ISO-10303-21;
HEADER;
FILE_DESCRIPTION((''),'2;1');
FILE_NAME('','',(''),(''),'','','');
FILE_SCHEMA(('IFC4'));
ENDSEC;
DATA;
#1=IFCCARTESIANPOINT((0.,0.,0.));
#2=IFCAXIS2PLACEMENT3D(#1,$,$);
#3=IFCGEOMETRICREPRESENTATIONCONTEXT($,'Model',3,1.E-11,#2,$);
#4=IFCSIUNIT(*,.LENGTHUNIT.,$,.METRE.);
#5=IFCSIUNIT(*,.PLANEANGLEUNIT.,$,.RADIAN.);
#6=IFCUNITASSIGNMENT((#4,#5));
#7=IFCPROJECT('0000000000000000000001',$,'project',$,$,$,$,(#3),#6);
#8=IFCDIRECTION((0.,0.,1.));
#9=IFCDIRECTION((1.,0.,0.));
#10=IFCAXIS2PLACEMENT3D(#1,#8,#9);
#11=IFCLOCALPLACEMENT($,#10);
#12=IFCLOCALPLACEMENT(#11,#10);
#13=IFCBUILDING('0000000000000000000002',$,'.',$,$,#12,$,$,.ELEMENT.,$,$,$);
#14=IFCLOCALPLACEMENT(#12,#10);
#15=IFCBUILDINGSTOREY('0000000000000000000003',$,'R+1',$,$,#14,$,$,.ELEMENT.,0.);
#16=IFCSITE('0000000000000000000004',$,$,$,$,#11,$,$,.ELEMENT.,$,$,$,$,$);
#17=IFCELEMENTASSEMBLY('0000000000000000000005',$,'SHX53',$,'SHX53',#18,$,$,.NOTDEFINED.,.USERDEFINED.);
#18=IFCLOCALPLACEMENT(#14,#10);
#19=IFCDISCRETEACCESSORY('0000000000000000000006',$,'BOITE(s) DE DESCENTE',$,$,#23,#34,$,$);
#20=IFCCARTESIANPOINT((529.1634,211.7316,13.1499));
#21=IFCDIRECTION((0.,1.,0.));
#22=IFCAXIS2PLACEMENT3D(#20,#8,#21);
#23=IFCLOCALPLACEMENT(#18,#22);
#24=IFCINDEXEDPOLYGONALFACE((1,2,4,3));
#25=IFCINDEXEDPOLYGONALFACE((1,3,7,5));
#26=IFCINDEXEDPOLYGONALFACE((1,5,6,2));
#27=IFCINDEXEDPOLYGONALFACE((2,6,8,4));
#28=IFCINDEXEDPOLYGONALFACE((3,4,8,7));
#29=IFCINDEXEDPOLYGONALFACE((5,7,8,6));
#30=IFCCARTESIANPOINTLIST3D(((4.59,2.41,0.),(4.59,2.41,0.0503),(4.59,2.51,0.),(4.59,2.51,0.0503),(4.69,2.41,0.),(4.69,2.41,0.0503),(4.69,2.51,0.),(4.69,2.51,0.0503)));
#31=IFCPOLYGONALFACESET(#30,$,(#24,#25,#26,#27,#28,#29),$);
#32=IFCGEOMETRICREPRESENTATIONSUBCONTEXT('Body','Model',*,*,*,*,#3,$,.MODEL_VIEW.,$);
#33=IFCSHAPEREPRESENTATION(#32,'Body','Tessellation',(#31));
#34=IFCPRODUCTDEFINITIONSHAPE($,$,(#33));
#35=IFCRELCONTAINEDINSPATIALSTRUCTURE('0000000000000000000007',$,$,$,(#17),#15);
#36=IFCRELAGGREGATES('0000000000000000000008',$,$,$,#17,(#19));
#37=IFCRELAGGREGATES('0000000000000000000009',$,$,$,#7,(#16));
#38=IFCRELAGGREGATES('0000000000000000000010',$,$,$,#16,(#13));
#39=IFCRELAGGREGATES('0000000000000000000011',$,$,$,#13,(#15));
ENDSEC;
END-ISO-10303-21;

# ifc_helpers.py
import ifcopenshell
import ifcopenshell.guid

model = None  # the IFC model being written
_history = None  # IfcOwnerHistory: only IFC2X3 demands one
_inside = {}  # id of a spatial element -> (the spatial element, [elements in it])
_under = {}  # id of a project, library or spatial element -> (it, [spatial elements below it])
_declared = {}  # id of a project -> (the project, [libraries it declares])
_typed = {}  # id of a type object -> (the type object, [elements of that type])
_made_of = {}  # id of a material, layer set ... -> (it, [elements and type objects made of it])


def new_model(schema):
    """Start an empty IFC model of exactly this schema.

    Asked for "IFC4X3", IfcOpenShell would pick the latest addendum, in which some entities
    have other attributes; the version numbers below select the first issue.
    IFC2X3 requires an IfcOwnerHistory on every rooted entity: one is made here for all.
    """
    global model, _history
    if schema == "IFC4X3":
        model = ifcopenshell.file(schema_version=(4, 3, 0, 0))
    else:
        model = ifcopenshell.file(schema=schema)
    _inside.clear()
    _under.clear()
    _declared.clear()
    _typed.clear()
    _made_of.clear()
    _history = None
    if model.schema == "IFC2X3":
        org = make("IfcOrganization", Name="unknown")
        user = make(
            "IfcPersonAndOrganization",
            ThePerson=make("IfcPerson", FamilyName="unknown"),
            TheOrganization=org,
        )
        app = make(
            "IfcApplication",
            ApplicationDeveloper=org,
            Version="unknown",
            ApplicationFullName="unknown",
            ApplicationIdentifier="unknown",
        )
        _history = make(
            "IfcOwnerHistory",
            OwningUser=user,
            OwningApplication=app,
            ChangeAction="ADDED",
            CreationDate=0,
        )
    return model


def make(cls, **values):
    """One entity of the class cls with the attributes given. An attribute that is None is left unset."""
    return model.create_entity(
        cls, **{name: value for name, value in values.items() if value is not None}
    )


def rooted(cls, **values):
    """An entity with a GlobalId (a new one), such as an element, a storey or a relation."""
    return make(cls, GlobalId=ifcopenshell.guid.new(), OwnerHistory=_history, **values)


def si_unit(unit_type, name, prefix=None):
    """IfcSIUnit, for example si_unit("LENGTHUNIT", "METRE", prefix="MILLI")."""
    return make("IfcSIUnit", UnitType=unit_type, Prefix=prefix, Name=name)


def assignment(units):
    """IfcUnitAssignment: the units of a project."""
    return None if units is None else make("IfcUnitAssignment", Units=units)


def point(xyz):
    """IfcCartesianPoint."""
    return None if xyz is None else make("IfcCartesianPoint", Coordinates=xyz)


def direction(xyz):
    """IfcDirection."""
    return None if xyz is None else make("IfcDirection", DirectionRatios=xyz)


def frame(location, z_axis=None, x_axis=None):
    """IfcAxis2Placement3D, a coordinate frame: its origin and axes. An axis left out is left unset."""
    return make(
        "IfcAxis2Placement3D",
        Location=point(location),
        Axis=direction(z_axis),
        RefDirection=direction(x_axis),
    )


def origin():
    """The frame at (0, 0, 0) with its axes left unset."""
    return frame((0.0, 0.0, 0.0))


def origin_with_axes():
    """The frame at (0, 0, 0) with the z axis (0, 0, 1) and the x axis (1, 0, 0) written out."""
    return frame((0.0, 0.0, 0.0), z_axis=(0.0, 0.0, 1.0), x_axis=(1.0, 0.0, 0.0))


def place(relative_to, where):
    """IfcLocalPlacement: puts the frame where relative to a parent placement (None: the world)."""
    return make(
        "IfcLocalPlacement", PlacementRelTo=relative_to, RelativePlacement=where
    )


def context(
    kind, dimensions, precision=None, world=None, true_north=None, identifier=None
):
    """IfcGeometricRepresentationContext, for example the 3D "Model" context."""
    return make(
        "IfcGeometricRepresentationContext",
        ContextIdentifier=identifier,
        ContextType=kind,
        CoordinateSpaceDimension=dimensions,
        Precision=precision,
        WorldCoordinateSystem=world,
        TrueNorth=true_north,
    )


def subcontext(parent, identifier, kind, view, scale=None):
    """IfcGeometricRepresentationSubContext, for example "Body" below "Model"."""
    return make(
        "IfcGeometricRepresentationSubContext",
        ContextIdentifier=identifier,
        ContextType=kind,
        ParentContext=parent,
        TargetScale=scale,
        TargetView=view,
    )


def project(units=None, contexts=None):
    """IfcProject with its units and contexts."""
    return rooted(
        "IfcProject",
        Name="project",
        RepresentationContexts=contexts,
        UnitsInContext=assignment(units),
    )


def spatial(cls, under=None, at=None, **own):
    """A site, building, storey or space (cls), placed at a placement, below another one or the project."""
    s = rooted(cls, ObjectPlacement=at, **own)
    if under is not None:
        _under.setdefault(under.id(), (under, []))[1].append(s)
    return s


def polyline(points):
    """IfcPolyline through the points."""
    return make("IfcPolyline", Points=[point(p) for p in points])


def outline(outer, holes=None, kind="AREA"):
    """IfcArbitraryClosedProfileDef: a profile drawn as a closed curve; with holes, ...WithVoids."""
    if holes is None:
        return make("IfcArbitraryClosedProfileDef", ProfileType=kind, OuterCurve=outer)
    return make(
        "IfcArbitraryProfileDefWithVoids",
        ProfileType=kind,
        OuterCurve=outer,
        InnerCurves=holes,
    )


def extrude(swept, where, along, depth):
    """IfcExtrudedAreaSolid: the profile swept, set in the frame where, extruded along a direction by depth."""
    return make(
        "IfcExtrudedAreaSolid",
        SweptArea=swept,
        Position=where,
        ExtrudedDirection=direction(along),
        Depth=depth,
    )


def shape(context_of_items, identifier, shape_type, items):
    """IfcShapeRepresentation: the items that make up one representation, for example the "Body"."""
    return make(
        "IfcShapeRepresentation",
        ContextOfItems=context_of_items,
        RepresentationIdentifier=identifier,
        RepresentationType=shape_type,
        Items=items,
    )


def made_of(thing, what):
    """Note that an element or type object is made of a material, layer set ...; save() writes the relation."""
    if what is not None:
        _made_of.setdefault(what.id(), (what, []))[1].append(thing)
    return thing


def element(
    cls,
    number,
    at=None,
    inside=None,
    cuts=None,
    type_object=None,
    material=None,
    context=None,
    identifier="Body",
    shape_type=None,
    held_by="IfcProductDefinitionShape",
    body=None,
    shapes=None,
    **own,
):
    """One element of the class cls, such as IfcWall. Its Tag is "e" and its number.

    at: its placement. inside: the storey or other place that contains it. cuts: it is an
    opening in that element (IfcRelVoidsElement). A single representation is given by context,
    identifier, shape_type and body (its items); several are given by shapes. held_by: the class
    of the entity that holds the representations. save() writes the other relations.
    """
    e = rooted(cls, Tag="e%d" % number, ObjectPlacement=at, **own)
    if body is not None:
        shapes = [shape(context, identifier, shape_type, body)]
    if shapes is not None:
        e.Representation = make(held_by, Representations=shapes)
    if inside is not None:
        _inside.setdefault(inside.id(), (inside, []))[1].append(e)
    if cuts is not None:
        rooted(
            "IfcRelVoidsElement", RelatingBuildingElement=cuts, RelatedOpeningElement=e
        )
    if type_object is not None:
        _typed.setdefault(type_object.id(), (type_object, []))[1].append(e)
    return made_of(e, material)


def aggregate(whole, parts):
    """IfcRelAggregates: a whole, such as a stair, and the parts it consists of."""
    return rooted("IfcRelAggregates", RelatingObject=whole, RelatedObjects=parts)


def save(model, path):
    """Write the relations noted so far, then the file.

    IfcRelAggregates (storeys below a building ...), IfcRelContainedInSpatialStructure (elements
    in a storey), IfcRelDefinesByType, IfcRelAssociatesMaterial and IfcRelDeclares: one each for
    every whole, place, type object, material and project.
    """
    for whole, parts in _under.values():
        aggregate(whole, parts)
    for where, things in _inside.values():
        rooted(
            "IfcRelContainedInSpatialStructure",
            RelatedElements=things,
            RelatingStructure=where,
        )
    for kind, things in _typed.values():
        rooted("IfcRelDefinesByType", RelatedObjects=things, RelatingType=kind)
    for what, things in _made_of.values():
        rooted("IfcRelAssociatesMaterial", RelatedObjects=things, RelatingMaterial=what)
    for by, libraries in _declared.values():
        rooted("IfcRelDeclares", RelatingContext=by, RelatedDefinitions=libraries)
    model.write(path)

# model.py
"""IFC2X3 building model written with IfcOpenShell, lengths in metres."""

from ifc_helpers import new_model, si_unit, frame, origin, origin_with_axes, place, context, subcontext, project, spatial, polyline, outline, extrude, element, aggregate, save


model = new_model("IFC2X3")

# Units and contexts
model_context = context("Model", 3, precision=1e-11, world=origin())
body_context = subcontext(model_context, "Body", "Model", "MODEL_VIEW")
ifc_project = project(units=[si_unit("LENGTHUNIT", "METRE"), si_unit("PLANEANGLEUNIT", "RADIAN")], contexts=[model_context])

# Site, building, storey
site_placement = place(None, origin_with_axes())
site = spatial("IfcSite", under=ifc_project, at=site_placement, CompositionType="ELEMENT")
building_placement = place(site_placement, origin_with_axes())
building = spatial("IfcBuilding", under=site, at=building_placement, Name=".", CompositionType="ELEMENT")
storey_placement = place(building_placement, origin_with_axes())
storey = spatial("IfcBuildingStorey", under=building, at=storey_placement, Name="R+1", CompositionType="ELEMENT", Elevation=0.0)

# Element assembly, discrete accessory
assembly_1_placement = place(storey_placement, origin_with_axes())
assembly_1 = element("IfcElementAssembly", 1, at=assembly_1_placement, inside=storey, Name="SHX53", ObjectType="SHX53", AssemblyPlace="NOTDEFINED", PredefinedType="USERDEFINED")
discrete_accessory_1_placement = place(assembly_1_placement, frame((529.1634, 211.7316, 13.1499), z_axis=(0.0, 0.0, 1.0), x_axis=(0.0, 1.0, 0.0)))
discrete_accessory_1 = element("IfcDiscreteAccessory", 2, at=discrete_accessory_1_placement, Name="BOITE(s) DE DESCENTE", context=body_context, shape_type="SweptSolid", body=[
    extrude(outline(polyline([(2.41, -4.59), (2.41, -4.69), (2.51, -4.69), (2.51, -4.59), (2.41, -4.59)])), frame((0.0, 0.0, 0.0), z_axis=(0.0, 0.0, 1.0), x_axis=(0.0, 1.0, 0.0)), (0.0, 0.0, 1.0), 0.0503),
])
aggregate(assembly_1, [discrete_accessory_1])

save(model, "model.ifc")
